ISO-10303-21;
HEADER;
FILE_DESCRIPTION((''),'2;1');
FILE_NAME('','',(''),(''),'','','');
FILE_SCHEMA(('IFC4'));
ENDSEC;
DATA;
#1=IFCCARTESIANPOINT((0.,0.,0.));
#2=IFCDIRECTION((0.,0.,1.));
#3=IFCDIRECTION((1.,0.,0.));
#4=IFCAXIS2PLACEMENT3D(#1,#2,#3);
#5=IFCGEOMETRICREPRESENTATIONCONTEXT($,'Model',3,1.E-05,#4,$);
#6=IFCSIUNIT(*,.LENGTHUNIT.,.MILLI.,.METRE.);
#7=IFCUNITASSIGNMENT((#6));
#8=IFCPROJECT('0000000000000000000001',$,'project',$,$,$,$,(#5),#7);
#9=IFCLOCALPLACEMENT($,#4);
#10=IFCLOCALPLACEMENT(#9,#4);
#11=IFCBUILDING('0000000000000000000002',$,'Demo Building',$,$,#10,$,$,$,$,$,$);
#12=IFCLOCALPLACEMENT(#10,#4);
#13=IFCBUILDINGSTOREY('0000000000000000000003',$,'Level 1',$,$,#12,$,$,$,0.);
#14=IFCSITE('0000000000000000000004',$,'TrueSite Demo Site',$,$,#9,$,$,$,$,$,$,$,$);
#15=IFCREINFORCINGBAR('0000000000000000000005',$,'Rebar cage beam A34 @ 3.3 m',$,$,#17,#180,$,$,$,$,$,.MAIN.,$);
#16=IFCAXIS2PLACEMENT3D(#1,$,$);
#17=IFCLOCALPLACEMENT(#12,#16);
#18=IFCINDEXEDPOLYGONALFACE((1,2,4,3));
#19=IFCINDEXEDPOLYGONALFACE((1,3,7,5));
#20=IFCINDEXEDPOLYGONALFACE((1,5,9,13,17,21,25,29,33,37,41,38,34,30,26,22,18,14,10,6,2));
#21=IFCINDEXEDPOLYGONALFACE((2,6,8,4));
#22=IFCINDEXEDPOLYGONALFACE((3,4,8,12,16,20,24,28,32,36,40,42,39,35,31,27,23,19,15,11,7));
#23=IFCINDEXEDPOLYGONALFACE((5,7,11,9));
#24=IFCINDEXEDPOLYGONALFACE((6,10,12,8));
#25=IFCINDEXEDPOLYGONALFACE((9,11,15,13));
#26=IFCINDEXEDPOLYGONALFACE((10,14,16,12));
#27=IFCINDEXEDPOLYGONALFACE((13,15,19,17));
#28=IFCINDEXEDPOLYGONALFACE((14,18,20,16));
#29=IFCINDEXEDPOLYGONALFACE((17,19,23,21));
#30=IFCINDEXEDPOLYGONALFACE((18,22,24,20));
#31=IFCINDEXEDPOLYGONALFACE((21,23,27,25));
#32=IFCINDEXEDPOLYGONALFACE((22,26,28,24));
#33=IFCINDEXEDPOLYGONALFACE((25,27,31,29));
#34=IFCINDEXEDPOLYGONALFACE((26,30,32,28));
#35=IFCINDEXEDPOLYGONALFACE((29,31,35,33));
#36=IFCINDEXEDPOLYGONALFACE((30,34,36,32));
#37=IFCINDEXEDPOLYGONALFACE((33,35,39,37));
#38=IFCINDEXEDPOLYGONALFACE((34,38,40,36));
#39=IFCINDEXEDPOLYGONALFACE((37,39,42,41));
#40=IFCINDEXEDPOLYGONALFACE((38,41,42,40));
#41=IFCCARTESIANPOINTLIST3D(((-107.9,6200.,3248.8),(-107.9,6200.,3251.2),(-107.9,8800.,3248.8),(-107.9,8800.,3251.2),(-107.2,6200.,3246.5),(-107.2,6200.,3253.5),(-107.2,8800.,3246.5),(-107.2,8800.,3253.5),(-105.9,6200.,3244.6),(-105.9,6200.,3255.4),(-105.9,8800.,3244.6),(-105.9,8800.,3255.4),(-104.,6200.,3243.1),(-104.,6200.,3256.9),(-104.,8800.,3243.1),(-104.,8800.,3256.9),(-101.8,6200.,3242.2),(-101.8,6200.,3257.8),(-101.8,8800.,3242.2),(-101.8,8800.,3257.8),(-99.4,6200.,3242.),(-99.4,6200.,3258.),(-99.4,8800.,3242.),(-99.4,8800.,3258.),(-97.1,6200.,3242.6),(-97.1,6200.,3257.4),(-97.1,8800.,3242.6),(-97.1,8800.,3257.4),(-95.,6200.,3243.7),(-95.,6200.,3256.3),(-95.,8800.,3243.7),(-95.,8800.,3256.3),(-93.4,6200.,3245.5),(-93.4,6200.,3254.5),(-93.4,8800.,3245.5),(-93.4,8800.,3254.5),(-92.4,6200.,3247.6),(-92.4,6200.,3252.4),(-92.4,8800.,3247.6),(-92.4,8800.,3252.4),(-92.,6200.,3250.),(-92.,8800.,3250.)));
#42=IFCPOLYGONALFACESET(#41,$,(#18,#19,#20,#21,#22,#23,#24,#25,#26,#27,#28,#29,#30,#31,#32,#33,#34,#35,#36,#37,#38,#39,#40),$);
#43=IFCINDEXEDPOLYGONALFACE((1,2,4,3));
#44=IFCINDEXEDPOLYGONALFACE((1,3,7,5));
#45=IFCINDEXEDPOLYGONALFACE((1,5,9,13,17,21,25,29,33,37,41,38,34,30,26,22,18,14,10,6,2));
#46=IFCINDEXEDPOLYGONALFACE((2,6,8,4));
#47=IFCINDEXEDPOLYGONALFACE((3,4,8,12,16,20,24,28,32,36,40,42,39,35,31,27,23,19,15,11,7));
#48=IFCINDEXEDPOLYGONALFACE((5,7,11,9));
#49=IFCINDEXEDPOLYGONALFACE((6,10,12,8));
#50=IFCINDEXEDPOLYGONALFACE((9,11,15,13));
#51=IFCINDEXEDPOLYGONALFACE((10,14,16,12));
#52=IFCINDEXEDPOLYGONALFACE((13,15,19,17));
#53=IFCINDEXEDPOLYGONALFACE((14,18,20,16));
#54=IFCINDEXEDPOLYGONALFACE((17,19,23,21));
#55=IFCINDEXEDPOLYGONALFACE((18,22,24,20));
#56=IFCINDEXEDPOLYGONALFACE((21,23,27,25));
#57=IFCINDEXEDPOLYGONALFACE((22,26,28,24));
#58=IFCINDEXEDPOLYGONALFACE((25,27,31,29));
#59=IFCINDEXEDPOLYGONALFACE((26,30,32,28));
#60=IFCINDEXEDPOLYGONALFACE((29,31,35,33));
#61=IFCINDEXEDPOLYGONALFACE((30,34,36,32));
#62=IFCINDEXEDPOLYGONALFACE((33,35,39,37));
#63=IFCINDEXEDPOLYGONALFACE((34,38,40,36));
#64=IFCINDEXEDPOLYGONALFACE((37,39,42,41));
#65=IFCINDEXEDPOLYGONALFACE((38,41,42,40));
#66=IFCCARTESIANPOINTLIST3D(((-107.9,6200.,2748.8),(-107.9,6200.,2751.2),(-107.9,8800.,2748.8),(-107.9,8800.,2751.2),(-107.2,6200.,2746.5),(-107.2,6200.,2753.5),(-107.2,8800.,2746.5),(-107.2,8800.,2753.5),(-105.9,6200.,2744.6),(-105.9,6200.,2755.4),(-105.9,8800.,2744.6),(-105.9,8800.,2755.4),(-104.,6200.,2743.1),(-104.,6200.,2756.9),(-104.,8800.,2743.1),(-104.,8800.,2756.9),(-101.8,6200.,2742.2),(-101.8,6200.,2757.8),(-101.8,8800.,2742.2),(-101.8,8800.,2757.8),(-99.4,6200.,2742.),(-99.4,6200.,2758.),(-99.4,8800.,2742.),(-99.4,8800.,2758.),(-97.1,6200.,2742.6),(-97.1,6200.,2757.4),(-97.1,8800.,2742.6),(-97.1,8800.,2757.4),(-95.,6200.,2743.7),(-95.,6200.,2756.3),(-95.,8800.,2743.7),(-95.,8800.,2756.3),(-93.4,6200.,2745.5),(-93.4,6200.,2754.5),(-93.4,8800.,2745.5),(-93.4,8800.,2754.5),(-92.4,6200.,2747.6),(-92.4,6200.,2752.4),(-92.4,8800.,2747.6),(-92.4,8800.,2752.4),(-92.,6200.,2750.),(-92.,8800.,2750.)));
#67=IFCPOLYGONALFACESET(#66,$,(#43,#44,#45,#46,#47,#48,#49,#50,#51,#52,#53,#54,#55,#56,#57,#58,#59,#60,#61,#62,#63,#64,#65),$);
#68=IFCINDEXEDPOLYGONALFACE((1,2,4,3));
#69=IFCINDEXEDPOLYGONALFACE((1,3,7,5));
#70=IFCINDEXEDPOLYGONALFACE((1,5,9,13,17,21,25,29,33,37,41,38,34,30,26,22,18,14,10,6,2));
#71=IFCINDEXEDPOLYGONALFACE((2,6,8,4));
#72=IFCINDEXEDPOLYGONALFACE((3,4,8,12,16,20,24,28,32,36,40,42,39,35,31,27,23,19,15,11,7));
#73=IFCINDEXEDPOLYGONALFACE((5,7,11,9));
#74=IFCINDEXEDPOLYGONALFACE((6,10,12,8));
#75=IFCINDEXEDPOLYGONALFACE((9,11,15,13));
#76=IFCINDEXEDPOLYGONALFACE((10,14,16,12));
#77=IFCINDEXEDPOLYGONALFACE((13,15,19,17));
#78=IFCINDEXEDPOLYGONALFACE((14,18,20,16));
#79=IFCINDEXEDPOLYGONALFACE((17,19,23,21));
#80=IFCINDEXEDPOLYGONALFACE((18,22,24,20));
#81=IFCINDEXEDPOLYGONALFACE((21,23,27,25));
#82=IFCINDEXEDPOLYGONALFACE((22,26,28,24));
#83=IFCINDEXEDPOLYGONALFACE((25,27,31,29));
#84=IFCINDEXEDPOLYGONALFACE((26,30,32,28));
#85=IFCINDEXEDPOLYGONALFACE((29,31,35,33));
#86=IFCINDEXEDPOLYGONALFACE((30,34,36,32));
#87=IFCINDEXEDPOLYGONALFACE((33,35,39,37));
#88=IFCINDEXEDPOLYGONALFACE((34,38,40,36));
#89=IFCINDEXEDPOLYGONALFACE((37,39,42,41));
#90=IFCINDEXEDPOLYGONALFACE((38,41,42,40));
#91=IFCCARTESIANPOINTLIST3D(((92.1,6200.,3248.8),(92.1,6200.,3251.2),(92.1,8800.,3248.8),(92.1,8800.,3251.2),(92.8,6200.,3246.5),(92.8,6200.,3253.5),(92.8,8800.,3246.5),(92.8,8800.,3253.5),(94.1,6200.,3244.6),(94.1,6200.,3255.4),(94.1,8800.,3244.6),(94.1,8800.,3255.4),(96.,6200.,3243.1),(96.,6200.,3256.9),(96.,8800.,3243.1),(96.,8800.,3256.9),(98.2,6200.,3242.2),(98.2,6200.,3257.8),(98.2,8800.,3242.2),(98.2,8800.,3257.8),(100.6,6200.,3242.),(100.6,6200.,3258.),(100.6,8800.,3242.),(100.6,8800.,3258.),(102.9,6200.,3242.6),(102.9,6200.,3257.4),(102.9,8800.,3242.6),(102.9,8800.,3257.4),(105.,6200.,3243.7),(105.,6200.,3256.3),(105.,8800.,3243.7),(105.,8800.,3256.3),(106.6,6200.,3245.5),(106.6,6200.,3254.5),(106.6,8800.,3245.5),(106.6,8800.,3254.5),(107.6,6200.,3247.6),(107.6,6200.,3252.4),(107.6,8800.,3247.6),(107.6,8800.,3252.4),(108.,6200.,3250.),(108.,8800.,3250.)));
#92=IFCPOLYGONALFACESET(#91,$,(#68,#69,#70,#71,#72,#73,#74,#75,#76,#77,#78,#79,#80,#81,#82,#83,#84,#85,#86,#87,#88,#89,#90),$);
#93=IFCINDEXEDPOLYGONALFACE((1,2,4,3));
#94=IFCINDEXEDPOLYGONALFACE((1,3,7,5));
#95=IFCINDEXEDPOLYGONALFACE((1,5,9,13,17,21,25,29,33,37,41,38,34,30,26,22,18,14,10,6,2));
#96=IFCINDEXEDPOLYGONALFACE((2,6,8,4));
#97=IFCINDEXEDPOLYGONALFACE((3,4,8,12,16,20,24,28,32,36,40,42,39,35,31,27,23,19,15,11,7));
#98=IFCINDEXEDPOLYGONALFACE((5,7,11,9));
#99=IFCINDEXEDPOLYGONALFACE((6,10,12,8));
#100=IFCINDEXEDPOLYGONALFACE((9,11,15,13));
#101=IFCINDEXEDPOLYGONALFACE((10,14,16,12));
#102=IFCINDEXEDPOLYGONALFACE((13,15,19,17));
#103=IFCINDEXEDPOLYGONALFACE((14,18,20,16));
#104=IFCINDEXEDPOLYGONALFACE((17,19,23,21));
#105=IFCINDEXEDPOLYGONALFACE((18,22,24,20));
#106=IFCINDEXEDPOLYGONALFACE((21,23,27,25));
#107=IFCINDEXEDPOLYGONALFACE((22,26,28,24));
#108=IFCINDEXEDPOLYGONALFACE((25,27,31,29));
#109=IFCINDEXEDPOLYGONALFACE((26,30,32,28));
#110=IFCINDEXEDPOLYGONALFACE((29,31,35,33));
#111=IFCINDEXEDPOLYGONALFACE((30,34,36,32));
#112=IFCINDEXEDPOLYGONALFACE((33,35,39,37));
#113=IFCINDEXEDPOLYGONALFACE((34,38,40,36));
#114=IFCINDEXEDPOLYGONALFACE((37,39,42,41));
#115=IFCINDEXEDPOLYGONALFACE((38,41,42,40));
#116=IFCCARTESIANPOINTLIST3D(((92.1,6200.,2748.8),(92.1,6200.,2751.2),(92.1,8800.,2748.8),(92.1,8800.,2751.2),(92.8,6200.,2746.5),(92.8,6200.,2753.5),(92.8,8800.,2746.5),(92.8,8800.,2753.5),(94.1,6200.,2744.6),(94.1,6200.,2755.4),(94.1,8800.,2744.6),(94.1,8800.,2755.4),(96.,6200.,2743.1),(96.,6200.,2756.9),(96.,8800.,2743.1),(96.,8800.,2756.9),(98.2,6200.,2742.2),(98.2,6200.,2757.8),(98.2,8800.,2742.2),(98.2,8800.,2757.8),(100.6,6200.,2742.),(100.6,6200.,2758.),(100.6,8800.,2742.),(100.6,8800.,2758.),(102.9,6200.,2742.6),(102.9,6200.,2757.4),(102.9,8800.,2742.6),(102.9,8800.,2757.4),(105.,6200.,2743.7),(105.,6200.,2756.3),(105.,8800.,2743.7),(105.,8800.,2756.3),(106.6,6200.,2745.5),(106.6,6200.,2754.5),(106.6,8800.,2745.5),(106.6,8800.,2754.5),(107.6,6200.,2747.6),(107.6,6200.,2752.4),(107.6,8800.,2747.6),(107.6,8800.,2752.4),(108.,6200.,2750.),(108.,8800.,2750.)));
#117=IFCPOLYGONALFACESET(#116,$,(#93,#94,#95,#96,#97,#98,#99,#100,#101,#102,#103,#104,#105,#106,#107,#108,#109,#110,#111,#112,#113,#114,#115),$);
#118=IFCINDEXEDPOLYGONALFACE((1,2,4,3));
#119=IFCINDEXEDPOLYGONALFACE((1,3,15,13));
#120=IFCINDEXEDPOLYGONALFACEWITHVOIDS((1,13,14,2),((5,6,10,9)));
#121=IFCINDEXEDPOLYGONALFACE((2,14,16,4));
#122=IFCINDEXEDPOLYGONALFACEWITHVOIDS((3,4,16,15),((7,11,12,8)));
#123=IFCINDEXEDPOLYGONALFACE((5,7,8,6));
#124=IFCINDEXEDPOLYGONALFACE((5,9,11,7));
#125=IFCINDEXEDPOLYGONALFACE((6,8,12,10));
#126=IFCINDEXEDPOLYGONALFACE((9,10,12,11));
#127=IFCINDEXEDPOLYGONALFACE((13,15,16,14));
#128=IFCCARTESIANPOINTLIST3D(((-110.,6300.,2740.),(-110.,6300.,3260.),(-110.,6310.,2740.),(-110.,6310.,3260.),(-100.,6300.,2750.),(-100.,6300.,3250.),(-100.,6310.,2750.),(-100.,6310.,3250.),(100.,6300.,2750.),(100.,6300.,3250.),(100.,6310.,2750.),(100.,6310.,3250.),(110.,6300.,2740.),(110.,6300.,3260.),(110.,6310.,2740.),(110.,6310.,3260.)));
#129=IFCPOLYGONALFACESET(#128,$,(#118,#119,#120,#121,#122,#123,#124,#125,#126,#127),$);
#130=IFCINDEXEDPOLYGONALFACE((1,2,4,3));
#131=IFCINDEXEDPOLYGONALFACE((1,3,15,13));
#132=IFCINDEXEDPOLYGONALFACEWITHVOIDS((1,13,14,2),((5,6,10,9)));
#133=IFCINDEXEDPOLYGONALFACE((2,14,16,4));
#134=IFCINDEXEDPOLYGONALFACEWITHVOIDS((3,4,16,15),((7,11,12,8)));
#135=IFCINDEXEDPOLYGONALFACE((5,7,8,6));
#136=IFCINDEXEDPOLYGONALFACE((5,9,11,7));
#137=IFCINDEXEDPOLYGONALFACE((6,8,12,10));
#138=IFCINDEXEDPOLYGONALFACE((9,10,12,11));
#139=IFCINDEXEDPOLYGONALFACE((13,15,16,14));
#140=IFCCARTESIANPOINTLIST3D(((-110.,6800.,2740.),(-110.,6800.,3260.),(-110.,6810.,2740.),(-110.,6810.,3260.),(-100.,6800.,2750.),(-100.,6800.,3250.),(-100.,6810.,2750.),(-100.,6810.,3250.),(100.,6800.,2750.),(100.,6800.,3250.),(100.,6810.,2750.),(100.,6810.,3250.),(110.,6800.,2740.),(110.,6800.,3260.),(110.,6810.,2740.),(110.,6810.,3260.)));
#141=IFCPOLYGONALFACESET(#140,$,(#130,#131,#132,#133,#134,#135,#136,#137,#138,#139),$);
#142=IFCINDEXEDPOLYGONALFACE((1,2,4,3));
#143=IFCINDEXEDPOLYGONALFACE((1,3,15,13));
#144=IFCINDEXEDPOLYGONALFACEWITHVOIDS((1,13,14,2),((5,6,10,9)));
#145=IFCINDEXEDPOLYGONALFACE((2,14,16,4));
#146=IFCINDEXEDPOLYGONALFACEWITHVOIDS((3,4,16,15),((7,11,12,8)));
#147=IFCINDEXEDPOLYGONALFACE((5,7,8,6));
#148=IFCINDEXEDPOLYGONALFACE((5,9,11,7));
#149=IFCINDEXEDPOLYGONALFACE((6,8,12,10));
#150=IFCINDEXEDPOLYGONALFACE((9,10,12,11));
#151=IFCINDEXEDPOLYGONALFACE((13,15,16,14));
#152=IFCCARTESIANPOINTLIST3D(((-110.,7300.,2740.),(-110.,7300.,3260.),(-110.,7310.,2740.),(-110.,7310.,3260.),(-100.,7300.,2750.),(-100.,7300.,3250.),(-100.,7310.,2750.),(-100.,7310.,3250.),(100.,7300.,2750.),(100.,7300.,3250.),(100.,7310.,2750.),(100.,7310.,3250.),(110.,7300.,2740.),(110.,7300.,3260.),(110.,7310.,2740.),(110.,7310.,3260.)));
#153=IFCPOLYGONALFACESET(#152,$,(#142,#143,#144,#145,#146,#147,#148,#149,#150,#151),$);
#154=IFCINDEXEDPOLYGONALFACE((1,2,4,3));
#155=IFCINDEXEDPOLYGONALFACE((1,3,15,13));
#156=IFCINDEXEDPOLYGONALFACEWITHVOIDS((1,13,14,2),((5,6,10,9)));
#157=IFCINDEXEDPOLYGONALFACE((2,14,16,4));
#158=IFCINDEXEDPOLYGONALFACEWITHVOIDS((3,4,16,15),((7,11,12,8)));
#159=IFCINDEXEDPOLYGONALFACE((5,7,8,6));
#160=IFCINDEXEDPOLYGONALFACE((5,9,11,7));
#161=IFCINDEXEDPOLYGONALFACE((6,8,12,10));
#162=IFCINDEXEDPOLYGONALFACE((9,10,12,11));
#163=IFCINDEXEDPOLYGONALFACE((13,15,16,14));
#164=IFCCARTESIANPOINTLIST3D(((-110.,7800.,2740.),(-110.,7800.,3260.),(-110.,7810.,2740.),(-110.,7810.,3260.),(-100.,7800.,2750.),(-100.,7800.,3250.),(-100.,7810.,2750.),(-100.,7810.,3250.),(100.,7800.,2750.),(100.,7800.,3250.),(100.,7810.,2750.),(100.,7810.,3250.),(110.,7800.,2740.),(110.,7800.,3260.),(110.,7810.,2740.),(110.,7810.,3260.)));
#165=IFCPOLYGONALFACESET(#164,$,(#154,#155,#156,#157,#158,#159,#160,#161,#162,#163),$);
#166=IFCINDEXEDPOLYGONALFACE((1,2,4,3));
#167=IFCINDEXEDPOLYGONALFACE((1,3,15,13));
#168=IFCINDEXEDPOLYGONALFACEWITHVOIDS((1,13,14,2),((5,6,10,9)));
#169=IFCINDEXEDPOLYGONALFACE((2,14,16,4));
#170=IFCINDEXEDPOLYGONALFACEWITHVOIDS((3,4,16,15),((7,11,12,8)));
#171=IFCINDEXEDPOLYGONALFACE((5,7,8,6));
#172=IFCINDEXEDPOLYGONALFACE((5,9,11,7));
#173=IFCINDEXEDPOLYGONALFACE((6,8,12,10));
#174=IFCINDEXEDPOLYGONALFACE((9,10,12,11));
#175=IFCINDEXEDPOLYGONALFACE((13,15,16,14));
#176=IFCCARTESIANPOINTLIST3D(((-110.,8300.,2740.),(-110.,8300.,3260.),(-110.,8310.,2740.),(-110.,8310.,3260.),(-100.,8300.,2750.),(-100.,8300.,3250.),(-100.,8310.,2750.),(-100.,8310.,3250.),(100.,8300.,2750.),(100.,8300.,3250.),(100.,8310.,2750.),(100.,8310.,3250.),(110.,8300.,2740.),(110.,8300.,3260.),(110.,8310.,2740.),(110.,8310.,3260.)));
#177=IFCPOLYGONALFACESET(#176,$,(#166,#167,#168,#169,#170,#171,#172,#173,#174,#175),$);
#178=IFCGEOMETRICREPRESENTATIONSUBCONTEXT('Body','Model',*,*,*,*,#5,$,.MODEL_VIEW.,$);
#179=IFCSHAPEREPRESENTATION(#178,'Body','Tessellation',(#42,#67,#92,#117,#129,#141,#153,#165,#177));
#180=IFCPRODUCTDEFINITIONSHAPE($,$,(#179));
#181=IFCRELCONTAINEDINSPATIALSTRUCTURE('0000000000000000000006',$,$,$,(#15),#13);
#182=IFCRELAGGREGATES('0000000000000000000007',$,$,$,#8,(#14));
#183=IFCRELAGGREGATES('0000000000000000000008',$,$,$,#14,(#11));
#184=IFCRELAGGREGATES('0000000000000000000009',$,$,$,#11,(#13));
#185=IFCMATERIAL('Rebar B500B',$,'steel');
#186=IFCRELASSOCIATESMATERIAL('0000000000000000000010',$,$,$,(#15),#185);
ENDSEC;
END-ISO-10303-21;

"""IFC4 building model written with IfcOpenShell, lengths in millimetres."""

from ifc_helpers import new_model, si_unit, frame, origin_with_axes, place, context, subcontext, project, spatial, hollow_rectangle, circle, extrude, material, element, save


model = new_model("IFC4")

# Units and contexts
model_context = context("Model", 3, precision=1e-05, world=origin_with_axes())
body_context = subcontext(model_context, "Body", "Model", "MODEL_VIEW")
ifc_project = project(units=[si_unit("LENGTHUNIT", "METRE", prefix="MILLI")], contexts=[model_context])

# Site, building, storey
site_placement = place(None, origin_with_axes())
site = spatial("IfcSite", under=ifc_project, at=site_placement, Name="TrueSite Demo Site")
building_placement = place(site_placement, origin_with_axes())
building = spatial("IfcBuilding", under=site, at=building_placement, Name="Demo Building")
storey_placement = place(building_placement, origin_with_axes())
storey = spatial("IfcBuildingStorey", under=building, at=storey_placement, Name="Level 1", Elevation=0.0)

# Reinforcing bar
ifc_material_1 = material(Name="Rebar B500B", Category="steel")
reinforcing_bar_1_placement = place(storey_placement, frame((0.0, 6200.0, 3000.0), z_axis=(0.0, 1.0, 0.0), x_axis=(1.0, 0.0, 0.0)))
element("IfcReinforcingBar", 1, at=reinforcing_bar_1_placement, inside=storey, material=ifc_material_1, Name="Rebar cage beam A34 @ 3.3 m", PredefinedType="MAIN", context=body_context, shape_type="SweptSolid", body=[
    extrude(circle(Radius=8.0), frame((-100.0, -250.0, 0.0)), (0.0, 0.0, 1.0), 2600.0),
    extrude(circle(Radius=8.0), frame((-100.0, 250.0, 0.0)), (0.0, 0.0, 1.0), 2600.0),
    extrude(circle(Radius=8.0), frame((100.0, -250.0, 0.0)), (0.0, 0.0, 1.0), 2600.0),
    extrude(circle(Radius=8.0), frame((100.0, 250.0, 0.0)), (0.0, 0.0, 1.0), 2600.0),
    extrude(hollow_rectangle(XDim=220.0, YDim=520.0, WallThickness=10.0), frame((0.0, 0.0, 100.0)), (0.0, 0.0, 1.0), 10.0),
    extrude(hollow_rectangle(XDim=220.0, YDim=520.0, WallThickness=10.0), frame((0.0, 0.0, 600.0)), (0.0, 0.0, 1.0), 10.0),
    extrude(hollow_rectangle(XDim=220.0, YDim=520.0, WallThickness=10.0), frame((0.0, 0.0, 1100.0)), (0.0, 0.0, 1.0), 10.0),
    extrude(hollow_rectangle(XDim=220.0, YDim=520.0, WallThickness=10.0), frame((0.0, 0.0, 1600.0)), (0.0, 0.0, 1.0), 10.0),
    extrude(hollow_rectangle(XDim=220.0, YDim=520.0, WallThickness=10.0), frame((0.0, 0.0, 2100.0)), (0.0, 0.0, 1.0), 10.0),
])

save(model, "model.ifc")
